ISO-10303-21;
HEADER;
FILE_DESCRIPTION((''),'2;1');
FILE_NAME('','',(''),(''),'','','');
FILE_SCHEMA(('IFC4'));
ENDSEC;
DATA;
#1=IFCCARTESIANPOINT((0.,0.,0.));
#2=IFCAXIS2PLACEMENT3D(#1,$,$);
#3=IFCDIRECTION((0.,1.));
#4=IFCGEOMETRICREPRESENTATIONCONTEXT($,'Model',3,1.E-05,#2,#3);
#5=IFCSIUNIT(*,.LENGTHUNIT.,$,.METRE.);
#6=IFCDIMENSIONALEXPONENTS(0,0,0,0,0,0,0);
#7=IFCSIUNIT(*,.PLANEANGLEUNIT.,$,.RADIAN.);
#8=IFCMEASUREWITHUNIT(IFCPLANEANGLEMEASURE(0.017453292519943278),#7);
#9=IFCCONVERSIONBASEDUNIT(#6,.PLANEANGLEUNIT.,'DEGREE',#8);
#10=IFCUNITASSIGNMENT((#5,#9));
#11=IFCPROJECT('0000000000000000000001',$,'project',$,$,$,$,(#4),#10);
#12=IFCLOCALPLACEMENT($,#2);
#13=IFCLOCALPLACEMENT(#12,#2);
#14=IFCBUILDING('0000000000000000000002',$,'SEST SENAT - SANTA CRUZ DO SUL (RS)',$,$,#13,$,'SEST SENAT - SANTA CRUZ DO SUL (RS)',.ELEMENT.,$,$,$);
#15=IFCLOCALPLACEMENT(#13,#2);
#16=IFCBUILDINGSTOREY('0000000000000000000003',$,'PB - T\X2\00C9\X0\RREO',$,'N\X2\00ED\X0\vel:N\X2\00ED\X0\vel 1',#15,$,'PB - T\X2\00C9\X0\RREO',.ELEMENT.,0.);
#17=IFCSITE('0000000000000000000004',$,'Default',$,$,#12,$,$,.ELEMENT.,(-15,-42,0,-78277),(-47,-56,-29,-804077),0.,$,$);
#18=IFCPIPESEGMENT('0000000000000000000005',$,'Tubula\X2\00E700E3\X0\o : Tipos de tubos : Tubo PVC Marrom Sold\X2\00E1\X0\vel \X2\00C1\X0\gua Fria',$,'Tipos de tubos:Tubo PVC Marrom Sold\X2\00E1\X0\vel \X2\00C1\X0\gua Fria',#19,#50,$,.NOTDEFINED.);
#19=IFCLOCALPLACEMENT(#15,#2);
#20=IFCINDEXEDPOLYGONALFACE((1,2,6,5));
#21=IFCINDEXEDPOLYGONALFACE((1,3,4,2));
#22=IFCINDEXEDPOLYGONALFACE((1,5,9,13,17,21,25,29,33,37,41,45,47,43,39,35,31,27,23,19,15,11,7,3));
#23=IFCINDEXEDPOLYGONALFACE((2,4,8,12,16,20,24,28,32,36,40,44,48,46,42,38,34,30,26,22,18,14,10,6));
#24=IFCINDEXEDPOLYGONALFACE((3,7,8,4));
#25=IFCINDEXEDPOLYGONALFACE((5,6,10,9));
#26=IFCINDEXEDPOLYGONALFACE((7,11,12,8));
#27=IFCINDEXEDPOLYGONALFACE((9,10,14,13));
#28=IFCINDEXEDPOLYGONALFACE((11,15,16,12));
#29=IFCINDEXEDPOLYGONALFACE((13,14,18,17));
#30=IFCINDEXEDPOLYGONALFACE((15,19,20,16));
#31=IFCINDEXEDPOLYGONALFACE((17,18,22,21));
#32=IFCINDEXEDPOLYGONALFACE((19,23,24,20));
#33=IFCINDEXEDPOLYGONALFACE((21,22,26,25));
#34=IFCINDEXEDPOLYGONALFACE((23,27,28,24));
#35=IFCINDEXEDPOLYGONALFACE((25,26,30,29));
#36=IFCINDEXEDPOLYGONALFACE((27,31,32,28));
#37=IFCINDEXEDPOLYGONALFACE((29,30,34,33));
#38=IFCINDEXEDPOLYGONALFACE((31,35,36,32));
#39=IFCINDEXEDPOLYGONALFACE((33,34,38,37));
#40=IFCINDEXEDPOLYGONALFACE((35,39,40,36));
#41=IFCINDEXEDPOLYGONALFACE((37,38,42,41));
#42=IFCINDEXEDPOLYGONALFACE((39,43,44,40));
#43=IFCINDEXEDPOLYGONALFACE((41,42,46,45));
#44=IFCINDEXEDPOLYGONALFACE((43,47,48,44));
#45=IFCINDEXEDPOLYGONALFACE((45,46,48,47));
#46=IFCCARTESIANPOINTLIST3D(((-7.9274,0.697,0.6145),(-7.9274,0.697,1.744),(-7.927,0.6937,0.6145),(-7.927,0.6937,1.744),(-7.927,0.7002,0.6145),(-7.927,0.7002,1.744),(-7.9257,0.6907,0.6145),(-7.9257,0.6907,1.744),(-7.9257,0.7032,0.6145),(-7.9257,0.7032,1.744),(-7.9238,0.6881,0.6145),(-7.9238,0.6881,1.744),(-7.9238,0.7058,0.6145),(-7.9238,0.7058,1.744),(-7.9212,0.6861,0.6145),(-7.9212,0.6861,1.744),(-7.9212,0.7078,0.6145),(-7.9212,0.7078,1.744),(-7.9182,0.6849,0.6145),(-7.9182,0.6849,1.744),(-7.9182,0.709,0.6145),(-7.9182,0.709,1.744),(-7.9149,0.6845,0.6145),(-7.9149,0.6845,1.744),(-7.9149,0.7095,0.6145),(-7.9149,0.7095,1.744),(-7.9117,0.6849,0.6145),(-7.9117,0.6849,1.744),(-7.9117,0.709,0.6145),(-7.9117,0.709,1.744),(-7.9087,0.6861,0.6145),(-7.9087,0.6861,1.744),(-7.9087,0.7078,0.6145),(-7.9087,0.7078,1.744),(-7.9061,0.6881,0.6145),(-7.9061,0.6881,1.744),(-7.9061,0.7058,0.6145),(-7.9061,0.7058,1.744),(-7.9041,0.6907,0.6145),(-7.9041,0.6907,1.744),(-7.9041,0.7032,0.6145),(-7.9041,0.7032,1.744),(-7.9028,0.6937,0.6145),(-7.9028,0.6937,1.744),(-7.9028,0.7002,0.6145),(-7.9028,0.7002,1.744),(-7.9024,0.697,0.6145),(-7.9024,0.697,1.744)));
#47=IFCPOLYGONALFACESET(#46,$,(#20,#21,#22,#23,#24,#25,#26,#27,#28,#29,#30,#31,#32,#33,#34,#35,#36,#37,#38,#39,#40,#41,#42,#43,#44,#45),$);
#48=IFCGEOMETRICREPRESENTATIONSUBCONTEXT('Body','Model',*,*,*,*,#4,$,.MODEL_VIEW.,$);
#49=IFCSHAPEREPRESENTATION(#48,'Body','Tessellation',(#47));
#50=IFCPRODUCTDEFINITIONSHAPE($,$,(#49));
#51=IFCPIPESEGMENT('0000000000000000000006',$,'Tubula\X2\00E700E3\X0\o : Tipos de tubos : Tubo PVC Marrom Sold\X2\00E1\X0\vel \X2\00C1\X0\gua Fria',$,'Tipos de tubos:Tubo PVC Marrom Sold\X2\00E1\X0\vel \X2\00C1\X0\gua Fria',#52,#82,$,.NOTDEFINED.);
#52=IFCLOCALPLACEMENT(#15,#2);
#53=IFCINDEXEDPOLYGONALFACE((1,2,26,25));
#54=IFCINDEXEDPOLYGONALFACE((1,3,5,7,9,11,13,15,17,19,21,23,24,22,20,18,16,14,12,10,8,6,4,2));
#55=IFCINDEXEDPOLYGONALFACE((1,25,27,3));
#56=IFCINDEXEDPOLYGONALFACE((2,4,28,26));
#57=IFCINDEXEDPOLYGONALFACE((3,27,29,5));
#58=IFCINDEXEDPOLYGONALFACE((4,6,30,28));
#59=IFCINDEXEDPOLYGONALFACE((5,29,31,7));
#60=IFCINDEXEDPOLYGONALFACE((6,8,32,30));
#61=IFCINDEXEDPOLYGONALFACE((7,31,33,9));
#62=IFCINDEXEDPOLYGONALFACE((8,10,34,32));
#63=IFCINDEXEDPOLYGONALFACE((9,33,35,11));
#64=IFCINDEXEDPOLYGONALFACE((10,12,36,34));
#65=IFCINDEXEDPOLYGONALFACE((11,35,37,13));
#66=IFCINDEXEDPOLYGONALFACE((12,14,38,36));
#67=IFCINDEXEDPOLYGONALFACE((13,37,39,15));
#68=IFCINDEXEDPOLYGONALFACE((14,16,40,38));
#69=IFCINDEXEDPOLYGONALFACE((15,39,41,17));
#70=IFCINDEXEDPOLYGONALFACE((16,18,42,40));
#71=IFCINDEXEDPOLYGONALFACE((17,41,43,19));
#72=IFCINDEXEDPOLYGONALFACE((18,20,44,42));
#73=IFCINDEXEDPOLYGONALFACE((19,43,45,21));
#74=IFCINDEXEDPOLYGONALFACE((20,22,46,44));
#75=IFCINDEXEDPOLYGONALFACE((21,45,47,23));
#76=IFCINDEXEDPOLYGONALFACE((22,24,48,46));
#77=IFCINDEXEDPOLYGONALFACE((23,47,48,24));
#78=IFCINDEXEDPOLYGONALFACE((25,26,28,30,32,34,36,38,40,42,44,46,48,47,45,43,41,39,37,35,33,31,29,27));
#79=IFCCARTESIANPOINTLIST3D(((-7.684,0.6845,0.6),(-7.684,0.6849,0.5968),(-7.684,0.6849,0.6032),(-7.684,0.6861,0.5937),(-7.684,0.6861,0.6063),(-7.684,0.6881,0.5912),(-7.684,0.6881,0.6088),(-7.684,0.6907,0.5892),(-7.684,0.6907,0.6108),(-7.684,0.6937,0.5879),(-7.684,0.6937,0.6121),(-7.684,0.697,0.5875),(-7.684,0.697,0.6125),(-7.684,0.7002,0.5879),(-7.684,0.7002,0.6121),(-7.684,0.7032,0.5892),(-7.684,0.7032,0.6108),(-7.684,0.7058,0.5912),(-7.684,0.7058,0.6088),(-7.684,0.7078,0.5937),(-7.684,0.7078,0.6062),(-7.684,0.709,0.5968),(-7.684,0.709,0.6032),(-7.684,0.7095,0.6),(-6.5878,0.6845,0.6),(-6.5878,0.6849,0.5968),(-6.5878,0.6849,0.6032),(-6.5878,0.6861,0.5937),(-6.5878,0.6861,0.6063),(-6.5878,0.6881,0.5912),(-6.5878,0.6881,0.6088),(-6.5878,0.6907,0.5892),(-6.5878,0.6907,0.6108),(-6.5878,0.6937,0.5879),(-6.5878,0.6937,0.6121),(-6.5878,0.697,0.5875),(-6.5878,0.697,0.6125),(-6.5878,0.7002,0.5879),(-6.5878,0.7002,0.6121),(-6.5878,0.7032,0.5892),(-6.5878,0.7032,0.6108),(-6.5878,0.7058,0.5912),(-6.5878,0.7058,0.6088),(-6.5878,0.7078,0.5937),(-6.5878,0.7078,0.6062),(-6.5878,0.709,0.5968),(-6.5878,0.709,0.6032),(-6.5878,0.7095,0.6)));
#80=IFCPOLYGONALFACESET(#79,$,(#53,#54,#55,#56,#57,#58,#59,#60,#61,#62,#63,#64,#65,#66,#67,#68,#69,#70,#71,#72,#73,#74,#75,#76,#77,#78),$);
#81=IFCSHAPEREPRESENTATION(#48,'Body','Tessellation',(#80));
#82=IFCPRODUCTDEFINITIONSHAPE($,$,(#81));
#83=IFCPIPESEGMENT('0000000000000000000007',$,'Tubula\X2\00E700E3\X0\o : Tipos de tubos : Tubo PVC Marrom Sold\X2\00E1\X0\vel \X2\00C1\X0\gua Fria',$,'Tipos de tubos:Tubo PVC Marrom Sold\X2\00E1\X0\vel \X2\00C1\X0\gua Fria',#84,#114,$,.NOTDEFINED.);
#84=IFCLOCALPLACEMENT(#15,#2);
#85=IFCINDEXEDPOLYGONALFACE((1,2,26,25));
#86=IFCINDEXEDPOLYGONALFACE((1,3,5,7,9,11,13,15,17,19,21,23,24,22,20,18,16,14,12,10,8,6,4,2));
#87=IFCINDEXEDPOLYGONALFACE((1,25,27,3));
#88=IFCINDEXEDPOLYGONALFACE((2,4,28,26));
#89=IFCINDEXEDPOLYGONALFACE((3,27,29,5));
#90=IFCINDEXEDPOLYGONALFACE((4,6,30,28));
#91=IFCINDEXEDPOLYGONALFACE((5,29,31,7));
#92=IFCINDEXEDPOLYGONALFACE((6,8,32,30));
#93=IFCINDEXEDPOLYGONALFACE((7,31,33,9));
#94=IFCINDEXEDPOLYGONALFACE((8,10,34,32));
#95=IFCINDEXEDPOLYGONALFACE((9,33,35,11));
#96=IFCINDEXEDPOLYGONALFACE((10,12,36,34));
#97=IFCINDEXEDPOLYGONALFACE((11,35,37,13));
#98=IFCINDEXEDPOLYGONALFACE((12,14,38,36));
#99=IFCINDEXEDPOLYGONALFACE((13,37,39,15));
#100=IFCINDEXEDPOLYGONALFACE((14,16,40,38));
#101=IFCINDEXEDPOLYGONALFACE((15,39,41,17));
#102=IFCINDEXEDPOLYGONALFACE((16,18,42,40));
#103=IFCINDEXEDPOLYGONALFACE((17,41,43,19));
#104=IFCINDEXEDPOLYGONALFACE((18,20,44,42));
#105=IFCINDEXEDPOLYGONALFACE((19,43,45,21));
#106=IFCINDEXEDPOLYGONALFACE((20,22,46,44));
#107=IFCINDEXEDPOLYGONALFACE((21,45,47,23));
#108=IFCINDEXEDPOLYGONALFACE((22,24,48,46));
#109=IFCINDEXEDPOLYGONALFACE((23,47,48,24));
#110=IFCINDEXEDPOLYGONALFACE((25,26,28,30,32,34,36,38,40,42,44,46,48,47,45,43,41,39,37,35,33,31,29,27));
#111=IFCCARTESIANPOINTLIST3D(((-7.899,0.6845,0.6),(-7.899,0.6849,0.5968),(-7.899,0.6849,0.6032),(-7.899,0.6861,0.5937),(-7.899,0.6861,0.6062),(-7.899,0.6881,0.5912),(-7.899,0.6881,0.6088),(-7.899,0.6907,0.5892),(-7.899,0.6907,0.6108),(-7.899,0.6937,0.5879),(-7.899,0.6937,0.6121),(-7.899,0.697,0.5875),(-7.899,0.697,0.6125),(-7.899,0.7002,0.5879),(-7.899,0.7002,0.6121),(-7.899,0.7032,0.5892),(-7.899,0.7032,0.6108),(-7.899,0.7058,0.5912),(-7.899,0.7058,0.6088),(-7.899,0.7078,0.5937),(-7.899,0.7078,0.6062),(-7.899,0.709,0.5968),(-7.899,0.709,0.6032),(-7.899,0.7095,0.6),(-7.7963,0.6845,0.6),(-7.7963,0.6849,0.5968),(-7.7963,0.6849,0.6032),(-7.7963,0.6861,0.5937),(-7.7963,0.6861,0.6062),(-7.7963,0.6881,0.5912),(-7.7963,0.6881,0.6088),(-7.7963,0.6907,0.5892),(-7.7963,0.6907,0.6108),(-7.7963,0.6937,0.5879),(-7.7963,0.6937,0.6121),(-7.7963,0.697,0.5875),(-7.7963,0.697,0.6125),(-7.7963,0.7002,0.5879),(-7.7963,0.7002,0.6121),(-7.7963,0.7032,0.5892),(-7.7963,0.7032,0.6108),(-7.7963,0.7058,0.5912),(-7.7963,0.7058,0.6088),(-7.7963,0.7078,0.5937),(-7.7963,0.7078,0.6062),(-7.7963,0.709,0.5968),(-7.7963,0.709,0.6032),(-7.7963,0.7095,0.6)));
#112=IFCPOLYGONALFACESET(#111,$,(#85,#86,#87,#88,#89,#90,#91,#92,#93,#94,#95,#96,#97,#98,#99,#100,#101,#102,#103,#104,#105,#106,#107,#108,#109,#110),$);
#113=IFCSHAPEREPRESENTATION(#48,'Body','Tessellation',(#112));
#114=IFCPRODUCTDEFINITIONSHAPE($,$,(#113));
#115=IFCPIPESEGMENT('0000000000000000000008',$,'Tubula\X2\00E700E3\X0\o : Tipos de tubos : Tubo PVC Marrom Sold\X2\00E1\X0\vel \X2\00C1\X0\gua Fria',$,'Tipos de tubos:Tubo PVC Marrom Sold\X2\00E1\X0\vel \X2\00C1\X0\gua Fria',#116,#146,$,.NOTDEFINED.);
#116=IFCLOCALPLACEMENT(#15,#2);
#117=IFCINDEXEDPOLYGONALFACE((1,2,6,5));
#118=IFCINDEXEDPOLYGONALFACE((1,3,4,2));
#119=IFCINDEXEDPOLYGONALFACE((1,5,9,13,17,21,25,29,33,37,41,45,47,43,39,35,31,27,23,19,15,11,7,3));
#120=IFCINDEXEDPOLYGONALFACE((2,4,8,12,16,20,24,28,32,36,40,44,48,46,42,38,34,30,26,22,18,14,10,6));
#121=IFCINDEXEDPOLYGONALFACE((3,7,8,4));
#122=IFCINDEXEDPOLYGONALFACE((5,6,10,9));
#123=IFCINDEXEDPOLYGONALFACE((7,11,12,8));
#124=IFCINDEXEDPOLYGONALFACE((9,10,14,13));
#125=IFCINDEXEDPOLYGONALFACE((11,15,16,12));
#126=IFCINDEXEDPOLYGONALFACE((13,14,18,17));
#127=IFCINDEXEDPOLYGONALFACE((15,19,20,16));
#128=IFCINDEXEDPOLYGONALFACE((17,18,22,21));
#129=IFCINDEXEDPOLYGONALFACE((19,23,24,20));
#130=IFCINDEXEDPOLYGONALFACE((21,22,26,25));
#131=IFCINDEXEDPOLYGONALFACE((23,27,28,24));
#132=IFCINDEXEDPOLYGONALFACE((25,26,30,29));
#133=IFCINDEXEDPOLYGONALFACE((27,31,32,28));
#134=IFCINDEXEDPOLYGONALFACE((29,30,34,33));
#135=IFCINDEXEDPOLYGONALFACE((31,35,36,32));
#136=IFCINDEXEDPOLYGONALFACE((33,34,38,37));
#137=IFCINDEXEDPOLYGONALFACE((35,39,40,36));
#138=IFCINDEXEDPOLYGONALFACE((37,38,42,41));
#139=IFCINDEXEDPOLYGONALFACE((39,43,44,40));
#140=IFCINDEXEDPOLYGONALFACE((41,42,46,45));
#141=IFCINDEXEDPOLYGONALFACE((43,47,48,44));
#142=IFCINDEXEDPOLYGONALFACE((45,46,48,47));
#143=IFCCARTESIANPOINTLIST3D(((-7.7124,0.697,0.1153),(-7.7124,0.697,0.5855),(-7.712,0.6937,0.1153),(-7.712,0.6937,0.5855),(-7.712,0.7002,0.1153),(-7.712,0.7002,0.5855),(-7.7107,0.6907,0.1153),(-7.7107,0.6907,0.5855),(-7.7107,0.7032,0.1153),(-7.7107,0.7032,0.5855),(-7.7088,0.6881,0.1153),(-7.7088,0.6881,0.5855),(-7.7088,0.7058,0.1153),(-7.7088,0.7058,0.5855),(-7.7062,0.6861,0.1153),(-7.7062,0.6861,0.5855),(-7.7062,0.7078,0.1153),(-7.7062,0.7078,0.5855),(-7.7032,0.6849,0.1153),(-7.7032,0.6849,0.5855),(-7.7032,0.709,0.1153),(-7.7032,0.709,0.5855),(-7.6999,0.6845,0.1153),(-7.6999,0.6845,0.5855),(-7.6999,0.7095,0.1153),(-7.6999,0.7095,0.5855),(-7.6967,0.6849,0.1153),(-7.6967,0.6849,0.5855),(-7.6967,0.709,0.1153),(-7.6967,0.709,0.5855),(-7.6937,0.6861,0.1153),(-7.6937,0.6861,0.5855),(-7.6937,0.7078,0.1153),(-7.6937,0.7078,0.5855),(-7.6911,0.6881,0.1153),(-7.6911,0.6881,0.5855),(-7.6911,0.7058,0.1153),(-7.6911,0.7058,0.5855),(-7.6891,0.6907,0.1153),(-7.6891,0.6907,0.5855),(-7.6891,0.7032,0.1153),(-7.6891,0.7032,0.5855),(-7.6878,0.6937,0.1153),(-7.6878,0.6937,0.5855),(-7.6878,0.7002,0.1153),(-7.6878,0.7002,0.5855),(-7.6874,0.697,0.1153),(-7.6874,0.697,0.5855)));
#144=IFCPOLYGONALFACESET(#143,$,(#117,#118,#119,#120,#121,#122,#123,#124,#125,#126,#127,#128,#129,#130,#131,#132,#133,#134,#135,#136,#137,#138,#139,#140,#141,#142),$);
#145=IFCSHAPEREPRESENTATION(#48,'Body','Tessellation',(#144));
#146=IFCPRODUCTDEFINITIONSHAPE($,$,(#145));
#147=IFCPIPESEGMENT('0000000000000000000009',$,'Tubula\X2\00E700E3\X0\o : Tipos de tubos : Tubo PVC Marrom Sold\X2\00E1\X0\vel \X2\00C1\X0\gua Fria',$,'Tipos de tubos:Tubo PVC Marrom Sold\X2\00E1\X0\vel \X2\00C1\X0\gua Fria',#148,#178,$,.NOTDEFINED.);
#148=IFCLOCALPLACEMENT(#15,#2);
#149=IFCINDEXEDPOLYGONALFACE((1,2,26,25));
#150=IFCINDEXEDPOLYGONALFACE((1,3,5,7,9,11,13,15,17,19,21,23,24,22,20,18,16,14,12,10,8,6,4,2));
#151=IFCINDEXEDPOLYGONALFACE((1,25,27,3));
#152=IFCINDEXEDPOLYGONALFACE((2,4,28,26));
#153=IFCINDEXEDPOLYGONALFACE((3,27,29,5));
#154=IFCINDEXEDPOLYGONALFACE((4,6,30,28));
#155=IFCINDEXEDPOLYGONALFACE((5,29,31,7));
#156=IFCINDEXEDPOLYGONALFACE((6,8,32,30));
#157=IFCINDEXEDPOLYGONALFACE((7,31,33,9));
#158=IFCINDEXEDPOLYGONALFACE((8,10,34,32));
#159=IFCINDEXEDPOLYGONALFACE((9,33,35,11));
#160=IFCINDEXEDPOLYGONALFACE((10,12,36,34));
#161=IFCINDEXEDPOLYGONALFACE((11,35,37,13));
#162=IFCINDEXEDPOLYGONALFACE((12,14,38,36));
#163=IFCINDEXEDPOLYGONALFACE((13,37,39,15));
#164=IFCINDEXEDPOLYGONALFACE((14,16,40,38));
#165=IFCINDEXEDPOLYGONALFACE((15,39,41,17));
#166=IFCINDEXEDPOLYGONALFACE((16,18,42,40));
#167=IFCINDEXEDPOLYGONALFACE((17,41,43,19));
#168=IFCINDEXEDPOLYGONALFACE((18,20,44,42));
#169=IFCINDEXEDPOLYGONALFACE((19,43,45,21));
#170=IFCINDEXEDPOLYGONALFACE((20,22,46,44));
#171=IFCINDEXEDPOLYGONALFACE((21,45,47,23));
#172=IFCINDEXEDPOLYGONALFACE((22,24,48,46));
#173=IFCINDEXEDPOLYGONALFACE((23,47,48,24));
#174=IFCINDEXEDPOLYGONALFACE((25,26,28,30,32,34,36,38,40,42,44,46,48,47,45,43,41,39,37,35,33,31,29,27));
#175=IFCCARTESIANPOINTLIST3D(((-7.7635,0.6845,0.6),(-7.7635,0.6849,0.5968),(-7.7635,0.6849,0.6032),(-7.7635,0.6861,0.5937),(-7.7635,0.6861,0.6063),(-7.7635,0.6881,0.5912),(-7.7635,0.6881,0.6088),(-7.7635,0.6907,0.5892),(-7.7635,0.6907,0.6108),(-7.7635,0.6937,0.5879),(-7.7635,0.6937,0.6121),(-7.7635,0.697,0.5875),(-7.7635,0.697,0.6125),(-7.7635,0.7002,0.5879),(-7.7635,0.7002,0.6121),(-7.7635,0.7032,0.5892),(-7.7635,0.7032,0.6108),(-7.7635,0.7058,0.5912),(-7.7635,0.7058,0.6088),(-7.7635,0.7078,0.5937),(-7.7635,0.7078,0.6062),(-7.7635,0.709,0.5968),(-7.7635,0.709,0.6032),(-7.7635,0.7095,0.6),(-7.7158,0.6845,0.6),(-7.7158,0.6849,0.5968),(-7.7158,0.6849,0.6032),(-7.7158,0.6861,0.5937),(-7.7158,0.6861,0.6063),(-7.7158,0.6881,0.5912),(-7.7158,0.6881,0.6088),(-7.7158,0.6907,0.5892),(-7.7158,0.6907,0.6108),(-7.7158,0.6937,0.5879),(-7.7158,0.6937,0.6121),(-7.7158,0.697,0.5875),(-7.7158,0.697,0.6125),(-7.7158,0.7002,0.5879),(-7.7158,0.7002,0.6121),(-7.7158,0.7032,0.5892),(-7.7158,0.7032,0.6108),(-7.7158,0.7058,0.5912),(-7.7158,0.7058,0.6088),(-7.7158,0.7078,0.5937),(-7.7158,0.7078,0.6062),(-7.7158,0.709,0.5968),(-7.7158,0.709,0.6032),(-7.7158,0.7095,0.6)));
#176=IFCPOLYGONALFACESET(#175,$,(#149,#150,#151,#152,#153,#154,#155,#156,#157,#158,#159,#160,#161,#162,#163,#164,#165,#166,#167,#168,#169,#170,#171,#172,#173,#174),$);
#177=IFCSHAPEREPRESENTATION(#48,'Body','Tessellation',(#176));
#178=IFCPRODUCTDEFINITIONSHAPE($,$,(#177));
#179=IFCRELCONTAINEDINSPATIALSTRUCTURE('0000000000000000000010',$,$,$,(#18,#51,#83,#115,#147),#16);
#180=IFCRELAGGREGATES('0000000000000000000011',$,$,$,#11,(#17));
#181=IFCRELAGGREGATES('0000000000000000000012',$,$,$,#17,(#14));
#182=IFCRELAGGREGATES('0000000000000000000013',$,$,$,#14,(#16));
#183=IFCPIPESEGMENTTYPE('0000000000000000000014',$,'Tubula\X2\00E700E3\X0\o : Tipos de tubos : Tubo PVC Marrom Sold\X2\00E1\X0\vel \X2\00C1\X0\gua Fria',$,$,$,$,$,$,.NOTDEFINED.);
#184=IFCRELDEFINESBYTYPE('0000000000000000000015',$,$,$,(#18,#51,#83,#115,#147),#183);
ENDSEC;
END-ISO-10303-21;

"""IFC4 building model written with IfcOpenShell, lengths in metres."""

from ifc_helpers import new_model, entity, si_unit, converted_unit, direction, frame, origin, place, context, subcontext, project, spatial, arc, indexed_curve, outline, extrude, type_object, element, save


model = new_model("IFC4")

# Units and contexts
model_context = context("Model", 3, precision=1e-05, world=origin(), true_north=direction((0.0, 1.0)))
body_context = subcontext(model_context, "Body", "Model", "MODEL_VIEW")
ifc_project = project(units=[si_unit("LENGTHUNIT", "METRE"), converted_unit("PLANEANGLEUNIT", "DEGREE", entity("IfcPlaneAngleMeasure", 0.017453292519943278), si_unit("PLANEANGLEUNIT", "RADIAN"), dimensions=[0, 0, 0, 0, 0, 0, 0])], contexts=[model_context])

# Site, building, storey
site_placement = place(None, origin())
site = spatial("IfcSite", under=ifc_project, at=site_placement, Name="Default", CompositionType="ELEMENT", RefLatitude=(-15, -42, 0, -78277), RefLongitude=(-47, -56, -29, -804077), RefElevation=0.0)
building_placement = place(site_placement, origin())
building = spatial("IfcBuilding", under=site, at=building_placement, Name="SEST SENAT - SANTA CRUZ DO SUL (RS)", LongName="SEST SENAT - SANTA CRUZ DO SUL (RS)", CompositionType="ELEMENT")
storey_placement = place(building_placement, origin())
storey = spatial("IfcBuildingStorey", under=building, at=storey_placement, Name="PB - TÉRREO", ObjectType="Nível:Nível 1", LongName="PB - TÉRREO", CompositionType="ELEMENT", Elevation=0.0)

# Pipe segments
pipe_segment_type_1 = type_object("IfcPipeSegmentType", Name="Tubulação : Tipos de tubos : Tubo PVC Marrom Soldável Água Fria", PredefinedType="NOTDEFINED")
pipe_segment_1_placement = place(storey_placement, frame((-7.929, 0.6829, 0.6145)))
element("IfcPipeSegment", 1, at=pipe_segment_1_placement, inside=storey, type_object=pipe_segment_type_1, Name="Tubulação : Tipos de tubos : Tubo PVC Marrom Soldável Água Fria", ObjectType="Tipos de tubos:Tubo PVC Marrom Soldável Água Fria", PredefinedType="NOTDEFINED", context=body_context, shape_type="SweptSolid", body=[
    extrude(outline(indexed_curve([(0.0125, 0.0), (0.0088, 0.0088), (0.0, 0.0125), (-0.0088, 0.0088), (-0.0125, 0.0), (-0.0088, -0.0088), (0.0, -0.0125), (0.0088, -0.0088)], segments=[arc(1, 2, 3), arc(3, 4, 5), arc(5, 6, 7), arc(7, 8, 1)], self_intersect=False)), frame((0.0141, 0.0141, 0.0)), (0.0, 0.0, 1.0), 1.1295),
])
pipe_segment_2_placement = place(storey_placement, frame((-7.684, 0.6829, 0.5859)))
element("IfcPipeSegment", 2, at=pipe_segment_2_placement, inside=storey, type_object=pipe_segment_type_1, Name="Tubulação : Tipos de tubos : Tubo PVC Marrom Soldável Água Fria", ObjectType="Tipos de tubos:Tubo PVC Marrom Soldável Água Fria", PredefinedType="NOTDEFINED", context=body_context, shape_type="SweptSolid", body=[
    extrude(outline(indexed_curve([(0.0125, 0.0), (0.0088, 0.0088), (0.0, 0.0125), (-0.0088, 0.0088), (-0.0125, 0.0), (-0.0088, -0.0088), (0.0, -0.0125), (0.0088, -0.0088)], segments=[arc(1, 2, 3), arc(3, 4, 5), arc(5, 6, 7), arc(7, 8, 1)], self_intersect=False)), frame((0.0, 0.0141, 0.0141), z_axis=(1.0, 0.0, 0.0), x_axis=(0.0, -1.0, 0.0)), (0.0, 0.0, 1.0), 1.0962),
])
pipe_segment_3_placement = place(storey_placement, frame((-7.899, 0.6829, 0.5859)))
element("IfcPipeSegment", 3, at=pipe_segment_3_placement, inside=storey, type_object=pipe_segment_type_1, Name="Tubulação : Tipos de tubos : Tubo PVC Marrom Soldável Água Fria", ObjectType="Tipos de tubos:Tubo PVC Marrom Soldável Água Fria", PredefinedType="NOTDEFINED", context=body_context, shape_type="SweptSolid", body=[
    extrude(outline(indexed_curve([(0.0125, 0.0), (0.0088, 0.0088), (0.0, 0.0125), (-0.0088, 0.0088), (-0.0125, 0.0), (-0.0088, -0.0088), (0.0, -0.0125), (0.0088, -0.0088)], segments=[arc(1, 2, 3), arc(3, 4, 5), arc(5, 6, 7), arc(7, 8, 1)], self_intersect=False)), frame((0.0, 0.0141, 0.0141), z_axis=(1.0, 0.0, 0.0), x_axis=(0.0, -1.0, 0.0)), (0.0, 0.0, 1.0), 0.1027),
])
pipe_segment_4_placement = place(storey_placement, frame((-7.714, 0.6829, 0.1153)))
element("IfcPipeSegment", 4, at=pipe_segment_4_placement, inside=storey, type_object=pipe_segment_type_1, Name="Tubulação : Tipos de tubos : Tubo PVC Marrom Soldável Água Fria", ObjectType="Tipos de tubos:Tubo PVC Marrom Soldável Água Fria", PredefinedType="NOTDEFINED", context=body_context, shape_type="SweptSolid", body=[
    extrude(outline(indexed_curve([(0.0125, 0.0), (0.0088, 0.0088), (0.0, 0.0125), (-0.0088, 0.0088), (-0.0125, 0.0), (-0.0088, -0.0088), (0.0, -0.0125), (0.0088, -0.0088)], segments=[arc(1, 2, 3), arc(3, 4, 5), arc(5, 6, 7), arc(7, 8, 1)], self_intersect=False)), frame((0.0141, 0.0141, 0.0)), (0.0, 0.0, 1.0), 0.4702),
])
pipe_segment_5_placement = place(storey_placement, frame((-7.7635, 0.6829, 0.5859)))
element("IfcPipeSegment", 5, at=pipe_segment_5_placement, inside=storey, type_object=pipe_segment_type_1, Name="Tubulação : Tipos de tubos : Tubo PVC Marrom Soldável Água Fria", ObjectType="Tipos de tubos:Tubo PVC Marrom Soldável Água Fria", PredefinedType="NOTDEFINED", context=body_context, shape_type="SweptSolid", body=[
    extrude(outline(indexed_curve([(0.0125, 0.0), (0.0088, 0.0088), (0.0, 0.0125), (-0.0088, 0.0088), (-0.0125, 0.0), (-0.0088, -0.0088), (0.0, -0.0125), (0.0088, -0.0088)], segments=[arc(1, 2, 3), arc(3, 4, 5), arc(5, 6, 7), arc(7, 8, 1)], self_intersect=False)), frame((0.0, 0.0141, 0.0141), z_axis=(1.0, 0.0, 0.0), x_axis=(0.0, -1.0, 0.0)), (0.0, 0.0, 1.0), 0.0477),
])

save(model, "model.ifc")
